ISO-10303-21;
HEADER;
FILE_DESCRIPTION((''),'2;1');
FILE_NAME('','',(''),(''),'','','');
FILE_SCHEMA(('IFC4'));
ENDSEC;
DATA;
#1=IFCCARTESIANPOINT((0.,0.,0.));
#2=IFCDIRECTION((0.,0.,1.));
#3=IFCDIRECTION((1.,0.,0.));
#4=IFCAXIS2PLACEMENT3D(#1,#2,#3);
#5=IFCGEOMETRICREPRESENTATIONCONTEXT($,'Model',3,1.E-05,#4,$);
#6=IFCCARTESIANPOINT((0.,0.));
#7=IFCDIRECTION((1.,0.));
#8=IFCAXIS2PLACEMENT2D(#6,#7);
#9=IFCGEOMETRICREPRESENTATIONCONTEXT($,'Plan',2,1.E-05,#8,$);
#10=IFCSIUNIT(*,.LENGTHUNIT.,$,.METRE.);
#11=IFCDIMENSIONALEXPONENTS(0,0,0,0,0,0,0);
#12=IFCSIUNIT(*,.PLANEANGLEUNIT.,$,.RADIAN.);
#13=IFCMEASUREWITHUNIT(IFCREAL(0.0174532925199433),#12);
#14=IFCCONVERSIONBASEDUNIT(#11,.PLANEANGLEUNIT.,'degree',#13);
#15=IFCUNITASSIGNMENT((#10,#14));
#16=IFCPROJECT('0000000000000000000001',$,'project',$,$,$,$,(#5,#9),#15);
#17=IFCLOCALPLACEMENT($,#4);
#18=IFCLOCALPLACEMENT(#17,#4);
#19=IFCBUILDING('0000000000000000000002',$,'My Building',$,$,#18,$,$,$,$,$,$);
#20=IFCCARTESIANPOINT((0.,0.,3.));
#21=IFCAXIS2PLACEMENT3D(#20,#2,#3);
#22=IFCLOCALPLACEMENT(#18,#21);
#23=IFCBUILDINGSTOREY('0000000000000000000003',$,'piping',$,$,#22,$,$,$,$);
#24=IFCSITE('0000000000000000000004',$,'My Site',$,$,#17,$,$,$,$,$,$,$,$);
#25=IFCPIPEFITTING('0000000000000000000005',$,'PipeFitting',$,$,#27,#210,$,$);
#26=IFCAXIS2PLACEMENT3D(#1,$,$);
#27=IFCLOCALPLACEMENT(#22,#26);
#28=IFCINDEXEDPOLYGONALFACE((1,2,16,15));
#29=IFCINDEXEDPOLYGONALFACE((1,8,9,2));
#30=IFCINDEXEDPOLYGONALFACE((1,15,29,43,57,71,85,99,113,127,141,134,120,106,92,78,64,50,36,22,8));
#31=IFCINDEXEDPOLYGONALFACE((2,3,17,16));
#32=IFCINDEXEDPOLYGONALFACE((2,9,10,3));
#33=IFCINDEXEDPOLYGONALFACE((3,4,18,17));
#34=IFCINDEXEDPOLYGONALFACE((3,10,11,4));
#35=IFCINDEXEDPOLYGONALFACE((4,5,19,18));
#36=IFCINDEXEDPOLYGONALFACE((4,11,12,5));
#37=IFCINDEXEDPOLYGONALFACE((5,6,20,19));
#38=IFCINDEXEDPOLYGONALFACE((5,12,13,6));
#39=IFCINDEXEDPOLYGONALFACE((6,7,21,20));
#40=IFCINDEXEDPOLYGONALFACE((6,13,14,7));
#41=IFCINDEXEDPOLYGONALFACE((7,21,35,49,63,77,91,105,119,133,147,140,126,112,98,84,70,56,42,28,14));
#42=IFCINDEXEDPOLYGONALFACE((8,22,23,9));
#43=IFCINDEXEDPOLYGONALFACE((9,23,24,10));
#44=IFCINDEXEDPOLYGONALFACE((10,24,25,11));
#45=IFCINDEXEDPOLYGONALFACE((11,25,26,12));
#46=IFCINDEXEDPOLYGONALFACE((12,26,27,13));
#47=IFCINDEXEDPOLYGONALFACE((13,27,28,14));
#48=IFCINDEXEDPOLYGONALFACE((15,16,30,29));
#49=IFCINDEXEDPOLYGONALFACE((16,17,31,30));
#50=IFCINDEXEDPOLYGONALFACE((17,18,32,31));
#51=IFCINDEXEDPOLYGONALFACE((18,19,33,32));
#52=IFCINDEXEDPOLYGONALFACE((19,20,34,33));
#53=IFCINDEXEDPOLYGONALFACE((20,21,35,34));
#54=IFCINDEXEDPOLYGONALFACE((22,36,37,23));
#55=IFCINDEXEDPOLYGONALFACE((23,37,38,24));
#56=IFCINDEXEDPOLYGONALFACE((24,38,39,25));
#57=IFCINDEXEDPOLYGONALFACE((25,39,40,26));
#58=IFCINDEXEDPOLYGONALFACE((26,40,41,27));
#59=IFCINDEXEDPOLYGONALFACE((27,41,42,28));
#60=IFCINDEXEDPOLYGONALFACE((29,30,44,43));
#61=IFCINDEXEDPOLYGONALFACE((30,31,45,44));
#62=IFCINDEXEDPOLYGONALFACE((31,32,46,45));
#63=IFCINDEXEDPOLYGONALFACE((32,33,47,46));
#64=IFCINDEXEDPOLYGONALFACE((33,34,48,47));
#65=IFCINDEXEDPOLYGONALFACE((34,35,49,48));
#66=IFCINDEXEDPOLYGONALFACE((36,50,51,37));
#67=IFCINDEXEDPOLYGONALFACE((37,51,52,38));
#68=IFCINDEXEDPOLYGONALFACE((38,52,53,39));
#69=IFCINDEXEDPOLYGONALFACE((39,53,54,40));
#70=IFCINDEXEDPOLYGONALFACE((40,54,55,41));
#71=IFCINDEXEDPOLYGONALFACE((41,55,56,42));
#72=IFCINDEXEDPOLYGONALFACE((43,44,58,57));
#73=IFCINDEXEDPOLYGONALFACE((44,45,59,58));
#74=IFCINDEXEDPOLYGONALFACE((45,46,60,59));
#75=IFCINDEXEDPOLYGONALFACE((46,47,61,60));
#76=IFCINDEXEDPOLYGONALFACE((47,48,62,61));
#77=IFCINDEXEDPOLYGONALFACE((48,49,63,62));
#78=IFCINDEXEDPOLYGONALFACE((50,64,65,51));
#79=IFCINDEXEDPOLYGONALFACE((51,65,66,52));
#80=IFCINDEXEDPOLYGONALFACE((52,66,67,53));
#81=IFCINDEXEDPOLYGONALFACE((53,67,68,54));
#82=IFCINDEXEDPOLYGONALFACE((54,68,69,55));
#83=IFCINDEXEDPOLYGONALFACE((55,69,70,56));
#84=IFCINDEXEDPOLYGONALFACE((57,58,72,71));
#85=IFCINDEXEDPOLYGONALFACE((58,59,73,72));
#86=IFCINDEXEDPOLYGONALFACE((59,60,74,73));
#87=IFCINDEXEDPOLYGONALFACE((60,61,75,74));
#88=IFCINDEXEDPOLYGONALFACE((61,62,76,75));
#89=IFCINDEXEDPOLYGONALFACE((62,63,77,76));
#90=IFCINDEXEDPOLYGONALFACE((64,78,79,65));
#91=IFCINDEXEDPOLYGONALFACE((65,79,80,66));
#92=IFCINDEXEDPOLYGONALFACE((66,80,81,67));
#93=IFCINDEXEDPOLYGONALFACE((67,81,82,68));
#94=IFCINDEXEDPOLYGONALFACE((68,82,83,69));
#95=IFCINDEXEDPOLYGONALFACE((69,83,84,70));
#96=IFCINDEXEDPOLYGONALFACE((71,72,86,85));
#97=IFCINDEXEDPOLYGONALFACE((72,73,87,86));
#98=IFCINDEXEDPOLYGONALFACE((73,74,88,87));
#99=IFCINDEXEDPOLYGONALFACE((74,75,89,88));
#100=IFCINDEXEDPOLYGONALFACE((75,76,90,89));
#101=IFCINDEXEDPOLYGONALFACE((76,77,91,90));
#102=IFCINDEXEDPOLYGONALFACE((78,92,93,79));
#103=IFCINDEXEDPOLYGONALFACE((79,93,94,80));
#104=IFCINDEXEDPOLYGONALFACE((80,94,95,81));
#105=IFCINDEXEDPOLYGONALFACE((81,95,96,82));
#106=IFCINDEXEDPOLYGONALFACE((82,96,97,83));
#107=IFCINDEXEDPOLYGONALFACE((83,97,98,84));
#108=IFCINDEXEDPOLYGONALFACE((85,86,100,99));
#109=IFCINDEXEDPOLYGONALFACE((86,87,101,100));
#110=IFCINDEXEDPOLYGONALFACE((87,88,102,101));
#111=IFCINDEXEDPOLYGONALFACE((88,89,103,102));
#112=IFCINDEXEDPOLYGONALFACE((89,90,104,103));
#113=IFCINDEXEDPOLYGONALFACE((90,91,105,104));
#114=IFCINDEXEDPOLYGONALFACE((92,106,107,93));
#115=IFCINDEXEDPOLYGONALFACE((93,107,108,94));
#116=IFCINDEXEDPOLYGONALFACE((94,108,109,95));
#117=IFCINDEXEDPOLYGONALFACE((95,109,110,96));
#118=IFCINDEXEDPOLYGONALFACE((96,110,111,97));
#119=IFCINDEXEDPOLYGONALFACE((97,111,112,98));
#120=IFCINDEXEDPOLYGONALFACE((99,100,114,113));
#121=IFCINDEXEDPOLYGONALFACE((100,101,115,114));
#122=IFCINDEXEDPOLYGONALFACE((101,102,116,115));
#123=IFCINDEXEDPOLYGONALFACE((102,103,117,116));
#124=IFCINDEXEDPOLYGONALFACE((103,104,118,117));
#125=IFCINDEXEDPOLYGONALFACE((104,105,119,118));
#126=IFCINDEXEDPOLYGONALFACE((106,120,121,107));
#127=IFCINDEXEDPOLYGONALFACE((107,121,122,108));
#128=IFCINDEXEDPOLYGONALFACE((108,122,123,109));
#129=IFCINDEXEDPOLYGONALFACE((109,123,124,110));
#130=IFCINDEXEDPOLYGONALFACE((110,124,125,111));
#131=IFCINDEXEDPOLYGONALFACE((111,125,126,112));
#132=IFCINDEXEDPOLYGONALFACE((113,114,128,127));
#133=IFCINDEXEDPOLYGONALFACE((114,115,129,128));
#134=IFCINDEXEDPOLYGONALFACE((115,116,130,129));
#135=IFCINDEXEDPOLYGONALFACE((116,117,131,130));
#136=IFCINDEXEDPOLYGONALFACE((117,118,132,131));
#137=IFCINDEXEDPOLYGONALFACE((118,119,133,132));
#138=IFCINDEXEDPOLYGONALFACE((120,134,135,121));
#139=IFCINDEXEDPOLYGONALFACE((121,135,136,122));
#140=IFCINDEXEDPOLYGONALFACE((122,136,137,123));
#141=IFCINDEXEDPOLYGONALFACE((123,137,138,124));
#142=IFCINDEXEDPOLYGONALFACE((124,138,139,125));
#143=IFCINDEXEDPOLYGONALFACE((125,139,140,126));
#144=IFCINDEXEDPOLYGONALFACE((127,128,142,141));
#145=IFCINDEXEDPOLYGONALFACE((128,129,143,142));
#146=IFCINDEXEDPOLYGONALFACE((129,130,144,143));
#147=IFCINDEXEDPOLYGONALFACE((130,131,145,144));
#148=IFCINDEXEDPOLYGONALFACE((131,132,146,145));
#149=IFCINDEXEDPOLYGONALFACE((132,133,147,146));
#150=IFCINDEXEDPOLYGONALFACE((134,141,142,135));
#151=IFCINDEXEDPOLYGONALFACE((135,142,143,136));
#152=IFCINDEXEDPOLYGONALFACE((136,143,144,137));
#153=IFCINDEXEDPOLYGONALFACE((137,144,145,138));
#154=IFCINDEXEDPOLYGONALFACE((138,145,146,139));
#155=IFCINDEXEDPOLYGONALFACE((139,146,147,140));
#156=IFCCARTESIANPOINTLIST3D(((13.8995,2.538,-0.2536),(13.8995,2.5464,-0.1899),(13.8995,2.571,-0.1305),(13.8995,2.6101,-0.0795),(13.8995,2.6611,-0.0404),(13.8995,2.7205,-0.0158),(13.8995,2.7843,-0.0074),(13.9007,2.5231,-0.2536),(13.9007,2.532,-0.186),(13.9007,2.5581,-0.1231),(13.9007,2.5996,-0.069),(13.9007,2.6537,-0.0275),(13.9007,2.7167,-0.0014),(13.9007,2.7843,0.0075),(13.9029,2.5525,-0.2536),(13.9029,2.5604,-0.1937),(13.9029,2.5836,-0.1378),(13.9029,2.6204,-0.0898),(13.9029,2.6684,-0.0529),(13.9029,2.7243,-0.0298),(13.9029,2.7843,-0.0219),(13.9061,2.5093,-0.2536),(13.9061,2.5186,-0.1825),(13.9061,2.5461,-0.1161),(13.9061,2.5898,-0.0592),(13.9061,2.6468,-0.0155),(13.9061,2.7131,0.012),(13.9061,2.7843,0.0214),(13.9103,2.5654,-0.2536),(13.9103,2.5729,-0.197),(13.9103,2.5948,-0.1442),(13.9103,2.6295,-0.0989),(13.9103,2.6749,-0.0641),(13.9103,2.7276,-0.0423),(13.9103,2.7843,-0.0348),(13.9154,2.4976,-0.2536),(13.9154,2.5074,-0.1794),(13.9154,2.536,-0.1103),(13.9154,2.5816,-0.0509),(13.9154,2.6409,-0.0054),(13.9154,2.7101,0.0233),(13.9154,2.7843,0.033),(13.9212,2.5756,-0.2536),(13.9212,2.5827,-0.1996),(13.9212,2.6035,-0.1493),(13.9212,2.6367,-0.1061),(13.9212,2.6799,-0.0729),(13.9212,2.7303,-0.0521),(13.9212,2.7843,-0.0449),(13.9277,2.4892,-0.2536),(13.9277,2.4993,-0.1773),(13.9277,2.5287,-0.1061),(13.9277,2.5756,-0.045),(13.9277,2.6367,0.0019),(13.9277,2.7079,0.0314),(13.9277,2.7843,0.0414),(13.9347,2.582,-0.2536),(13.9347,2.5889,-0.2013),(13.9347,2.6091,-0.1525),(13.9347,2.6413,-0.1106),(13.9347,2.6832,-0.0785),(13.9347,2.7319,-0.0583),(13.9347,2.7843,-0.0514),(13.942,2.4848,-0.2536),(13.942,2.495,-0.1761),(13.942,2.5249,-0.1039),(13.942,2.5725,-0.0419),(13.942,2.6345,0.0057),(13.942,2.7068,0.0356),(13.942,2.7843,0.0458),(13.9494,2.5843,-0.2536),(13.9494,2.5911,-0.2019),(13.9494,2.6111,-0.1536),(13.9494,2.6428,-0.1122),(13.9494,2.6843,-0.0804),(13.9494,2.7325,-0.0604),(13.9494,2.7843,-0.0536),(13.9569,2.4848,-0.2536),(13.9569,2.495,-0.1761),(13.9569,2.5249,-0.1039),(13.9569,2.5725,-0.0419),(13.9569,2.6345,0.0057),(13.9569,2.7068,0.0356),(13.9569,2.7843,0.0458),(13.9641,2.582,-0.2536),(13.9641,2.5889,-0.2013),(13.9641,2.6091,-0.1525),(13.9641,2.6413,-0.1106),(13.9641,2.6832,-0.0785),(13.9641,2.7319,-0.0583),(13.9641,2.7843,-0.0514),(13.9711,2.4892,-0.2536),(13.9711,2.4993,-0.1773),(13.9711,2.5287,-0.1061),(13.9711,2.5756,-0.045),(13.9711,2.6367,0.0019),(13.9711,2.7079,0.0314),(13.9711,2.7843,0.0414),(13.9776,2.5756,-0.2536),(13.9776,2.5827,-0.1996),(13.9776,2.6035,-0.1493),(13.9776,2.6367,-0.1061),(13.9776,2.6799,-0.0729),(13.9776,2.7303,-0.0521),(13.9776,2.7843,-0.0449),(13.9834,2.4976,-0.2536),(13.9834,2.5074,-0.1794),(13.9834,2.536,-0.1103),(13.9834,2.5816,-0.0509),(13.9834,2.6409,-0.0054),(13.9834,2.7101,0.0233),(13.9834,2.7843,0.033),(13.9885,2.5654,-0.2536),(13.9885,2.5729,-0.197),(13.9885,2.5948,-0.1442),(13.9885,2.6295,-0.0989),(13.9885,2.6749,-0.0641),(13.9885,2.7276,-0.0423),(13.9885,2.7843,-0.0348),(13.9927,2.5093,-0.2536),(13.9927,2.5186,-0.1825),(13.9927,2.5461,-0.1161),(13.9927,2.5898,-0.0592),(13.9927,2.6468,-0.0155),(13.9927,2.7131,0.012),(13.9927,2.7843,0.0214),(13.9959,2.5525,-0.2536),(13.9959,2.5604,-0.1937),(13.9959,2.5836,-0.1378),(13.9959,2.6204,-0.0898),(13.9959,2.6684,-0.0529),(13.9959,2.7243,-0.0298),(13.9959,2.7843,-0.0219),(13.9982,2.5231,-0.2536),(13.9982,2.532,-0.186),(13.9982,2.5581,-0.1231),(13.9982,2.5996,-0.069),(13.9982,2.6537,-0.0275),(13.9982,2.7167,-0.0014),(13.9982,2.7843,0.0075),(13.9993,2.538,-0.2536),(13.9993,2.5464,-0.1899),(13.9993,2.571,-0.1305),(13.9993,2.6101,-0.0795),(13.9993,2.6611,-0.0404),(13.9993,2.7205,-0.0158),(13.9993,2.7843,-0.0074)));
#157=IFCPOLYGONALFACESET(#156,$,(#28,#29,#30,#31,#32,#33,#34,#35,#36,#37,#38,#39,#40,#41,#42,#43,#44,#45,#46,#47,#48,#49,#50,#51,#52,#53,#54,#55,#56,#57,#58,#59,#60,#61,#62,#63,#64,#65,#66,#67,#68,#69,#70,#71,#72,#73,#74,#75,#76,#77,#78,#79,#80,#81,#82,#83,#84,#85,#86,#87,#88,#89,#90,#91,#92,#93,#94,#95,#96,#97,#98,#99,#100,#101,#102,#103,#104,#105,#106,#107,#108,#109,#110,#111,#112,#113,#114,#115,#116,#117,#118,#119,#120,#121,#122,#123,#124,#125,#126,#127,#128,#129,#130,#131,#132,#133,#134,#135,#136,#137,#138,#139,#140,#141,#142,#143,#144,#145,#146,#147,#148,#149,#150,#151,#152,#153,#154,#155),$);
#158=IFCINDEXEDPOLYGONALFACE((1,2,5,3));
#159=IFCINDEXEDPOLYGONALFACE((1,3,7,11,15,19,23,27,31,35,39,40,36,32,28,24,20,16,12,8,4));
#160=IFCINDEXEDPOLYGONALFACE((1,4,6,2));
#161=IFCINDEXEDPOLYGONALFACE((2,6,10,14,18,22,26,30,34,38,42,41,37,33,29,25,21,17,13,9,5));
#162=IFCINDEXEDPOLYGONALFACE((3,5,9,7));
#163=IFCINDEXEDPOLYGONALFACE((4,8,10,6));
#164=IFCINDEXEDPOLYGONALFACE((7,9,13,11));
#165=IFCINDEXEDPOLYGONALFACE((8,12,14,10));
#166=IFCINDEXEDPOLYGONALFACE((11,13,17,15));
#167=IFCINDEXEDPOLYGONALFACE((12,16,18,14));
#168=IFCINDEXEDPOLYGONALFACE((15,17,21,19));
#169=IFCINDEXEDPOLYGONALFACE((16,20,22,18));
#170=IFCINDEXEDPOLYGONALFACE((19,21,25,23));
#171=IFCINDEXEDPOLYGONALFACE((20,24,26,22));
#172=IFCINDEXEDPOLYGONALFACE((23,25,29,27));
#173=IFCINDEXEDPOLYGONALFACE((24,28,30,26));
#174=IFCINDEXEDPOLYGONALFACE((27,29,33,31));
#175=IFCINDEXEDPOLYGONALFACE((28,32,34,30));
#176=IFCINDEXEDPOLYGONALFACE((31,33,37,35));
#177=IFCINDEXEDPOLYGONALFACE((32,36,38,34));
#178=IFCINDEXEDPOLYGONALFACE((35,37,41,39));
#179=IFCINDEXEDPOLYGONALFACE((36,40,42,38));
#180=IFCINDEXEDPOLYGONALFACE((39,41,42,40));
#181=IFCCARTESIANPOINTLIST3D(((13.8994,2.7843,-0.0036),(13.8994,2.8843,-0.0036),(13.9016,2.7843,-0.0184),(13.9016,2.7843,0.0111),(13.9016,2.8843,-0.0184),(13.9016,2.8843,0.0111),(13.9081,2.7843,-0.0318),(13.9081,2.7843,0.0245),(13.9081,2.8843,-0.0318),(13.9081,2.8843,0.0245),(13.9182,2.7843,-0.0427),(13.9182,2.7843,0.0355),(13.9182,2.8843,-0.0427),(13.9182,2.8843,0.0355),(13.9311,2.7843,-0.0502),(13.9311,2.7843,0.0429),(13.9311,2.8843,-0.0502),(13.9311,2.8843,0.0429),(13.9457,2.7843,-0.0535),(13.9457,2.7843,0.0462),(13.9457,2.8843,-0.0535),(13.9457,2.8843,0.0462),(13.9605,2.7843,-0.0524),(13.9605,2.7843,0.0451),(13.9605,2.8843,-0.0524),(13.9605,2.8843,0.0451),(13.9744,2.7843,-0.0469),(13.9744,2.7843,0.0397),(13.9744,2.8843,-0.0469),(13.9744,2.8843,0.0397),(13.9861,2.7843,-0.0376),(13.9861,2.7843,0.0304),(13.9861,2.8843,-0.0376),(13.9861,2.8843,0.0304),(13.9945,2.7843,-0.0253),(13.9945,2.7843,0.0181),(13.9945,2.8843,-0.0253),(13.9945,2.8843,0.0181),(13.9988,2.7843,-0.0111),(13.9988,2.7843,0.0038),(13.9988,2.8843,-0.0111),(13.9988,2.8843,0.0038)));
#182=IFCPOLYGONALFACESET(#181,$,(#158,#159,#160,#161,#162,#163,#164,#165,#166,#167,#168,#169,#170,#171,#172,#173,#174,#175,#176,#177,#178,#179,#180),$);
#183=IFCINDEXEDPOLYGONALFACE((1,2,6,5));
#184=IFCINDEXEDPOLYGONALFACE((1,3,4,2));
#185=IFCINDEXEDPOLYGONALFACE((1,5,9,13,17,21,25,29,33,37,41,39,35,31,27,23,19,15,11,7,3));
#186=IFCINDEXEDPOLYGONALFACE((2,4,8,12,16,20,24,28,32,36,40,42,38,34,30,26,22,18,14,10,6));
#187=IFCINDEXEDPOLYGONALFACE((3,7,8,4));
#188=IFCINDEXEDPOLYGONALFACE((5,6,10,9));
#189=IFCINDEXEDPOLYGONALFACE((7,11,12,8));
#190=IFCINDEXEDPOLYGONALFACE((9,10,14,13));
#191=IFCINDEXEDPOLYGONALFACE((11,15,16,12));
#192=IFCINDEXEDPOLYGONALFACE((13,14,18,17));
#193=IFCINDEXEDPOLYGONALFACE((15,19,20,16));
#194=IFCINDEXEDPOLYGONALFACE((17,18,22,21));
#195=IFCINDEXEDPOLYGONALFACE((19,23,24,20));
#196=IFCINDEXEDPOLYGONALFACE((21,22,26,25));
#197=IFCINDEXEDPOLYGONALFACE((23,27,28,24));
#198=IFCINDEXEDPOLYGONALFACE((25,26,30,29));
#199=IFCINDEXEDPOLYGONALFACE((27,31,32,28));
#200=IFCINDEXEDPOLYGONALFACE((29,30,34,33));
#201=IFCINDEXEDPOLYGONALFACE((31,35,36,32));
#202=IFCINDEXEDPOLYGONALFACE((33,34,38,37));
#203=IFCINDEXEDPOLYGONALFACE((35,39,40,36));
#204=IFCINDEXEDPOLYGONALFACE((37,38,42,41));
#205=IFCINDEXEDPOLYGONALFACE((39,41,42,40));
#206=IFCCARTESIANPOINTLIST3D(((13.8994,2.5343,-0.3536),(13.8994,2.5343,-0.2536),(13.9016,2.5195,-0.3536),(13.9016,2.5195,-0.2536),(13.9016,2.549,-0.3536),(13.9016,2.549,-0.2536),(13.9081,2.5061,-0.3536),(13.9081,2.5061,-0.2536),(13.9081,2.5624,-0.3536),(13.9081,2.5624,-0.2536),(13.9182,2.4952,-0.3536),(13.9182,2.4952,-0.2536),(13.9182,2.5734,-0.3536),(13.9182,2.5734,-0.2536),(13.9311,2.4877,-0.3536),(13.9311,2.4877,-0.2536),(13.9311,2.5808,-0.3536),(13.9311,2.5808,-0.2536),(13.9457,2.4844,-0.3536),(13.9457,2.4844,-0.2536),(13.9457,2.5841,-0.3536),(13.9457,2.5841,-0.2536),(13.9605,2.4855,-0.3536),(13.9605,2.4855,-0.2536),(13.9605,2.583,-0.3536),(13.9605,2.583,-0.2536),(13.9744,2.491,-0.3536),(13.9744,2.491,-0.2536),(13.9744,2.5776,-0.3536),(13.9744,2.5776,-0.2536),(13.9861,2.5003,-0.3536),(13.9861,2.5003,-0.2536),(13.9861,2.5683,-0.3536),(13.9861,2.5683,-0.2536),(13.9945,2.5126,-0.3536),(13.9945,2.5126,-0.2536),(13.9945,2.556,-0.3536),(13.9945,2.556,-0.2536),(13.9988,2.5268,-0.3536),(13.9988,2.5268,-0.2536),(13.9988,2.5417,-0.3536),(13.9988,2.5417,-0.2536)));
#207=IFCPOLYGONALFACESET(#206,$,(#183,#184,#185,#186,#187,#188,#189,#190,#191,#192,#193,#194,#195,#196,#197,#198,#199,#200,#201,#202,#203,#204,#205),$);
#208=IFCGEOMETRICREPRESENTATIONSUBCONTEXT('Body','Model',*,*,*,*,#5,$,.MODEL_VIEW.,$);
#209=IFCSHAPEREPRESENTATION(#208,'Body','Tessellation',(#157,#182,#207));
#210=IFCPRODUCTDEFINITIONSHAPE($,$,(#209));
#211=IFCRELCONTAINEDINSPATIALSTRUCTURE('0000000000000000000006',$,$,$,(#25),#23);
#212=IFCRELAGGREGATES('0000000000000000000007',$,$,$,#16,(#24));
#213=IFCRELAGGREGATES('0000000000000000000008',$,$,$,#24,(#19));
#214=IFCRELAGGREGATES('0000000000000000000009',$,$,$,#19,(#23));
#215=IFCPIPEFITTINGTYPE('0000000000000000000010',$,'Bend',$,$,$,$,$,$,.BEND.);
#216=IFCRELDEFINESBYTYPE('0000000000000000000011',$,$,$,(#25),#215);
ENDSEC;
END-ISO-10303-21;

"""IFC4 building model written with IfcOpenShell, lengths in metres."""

from ifc_helpers import new_model, entity, si_unit, converted_unit, frame, origin_with_axes, origin_2d_with_axis, place, context, subcontext, project, spatial, circle, extrude, source, transform, mapped, type_object, type_shapes, element, save


model = new_model("IFC4")

# Units and contexts
model_context = context("Model", 3, precision=1e-05, world=origin_with_axes())
plan_context = context("Plan", 2, precision=1e-05, world=origin_2d_with_axis())
body_context = subcontext(model_context, "Body", "Model", "MODEL_VIEW")
ifc_project = project(units=[si_unit("LENGTHUNIT", "METRE"), converted_unit("PLANEANGLEUNIT", "degree", entity("IfcReal", 0.0174532925199433), si_unit("PLANEANGLEUNIT", "RADIAN"), dimensions=[0, 0, 0, 0, 0, 0, 0])], contexts=[model_context, plan_context])

# Site, building, storey
site_placement = place(None, origin_with_axes())
site = spatial("IfcSite", under=ifc_project, at=site_placement, Name="My Site")
building_placement = place(site_placement, origin_with_axes())
building = spatial("IfcBuilding", under=site, at=building_placement, Name="My Building")
storey_placement = place(building_placement, frame((0.0, 0.0, 3.0), z_axis=(0.0, 0.0, 1.0), x_axis=(1.0, 0.0, 0.0)))
storey = spatial("IfcBuildingStorey", under=building, at=storey_placement, Name="piping")

# Pipe fitting
pipe_fitting_type = type_object("IfcPipeFittingType", Name="Bend", PredefinedType="BEND")
shared_shape = source(origin_with_axes(), body_context, "Body", "SolidModel", [
    entity("IfcSweptDiskSolid", entity("IfcIndexedPolyCurve", entity("IfcCartesianPointList3D", [[0.0, 0.0, -0.1], [0.0, -0.0732, -0.2768], [0.0, -0.25, -0.35]]), [entity("IfcArcIndex", [1, 2, 3])]), 0.05),
    extrude(circle(Radius=0.05), origin_with_axes(), (0.0, 0.0, -1.0), 0.1),
    extrude(circle(Radius=0.05), frame((0.0, -0.25, -0.35), z_axis=(0.0, -1.0, 0.0), x_axis=(1.0, 0.0, 0.0)), (0.0, 0.0, 1.0), 0.1),
])
type_shapes(pipe_fitting_type, [shared_shape])
for number, where, z_axis, x_axis, name in (
    (1, (13.9494, 2.8843, -0.0036), (0.0, 1.0, 0.0), (-1.0, 0.0, 0.0), "PipeFitting"),
):
    element("IfcPipeFitting", number, at=place(storey_placement, frame(where, z_axis=z_axis, x_axis=x_axis)), inside=storey, type_object=pipe_fitting_type, Name=name, context=body_context, shape_type="MappedRepresentation", body=[
        mapped(shared_shape, transform((0.0, 0.0, 0.0), x_axis=(1.0, 0.0, 0.0), y_axis=(0.0, 1.0, 0.0), z_axis=(0.0, 0.0, 1.0), scale=1.0)),
    ])

save(model, "model.ifc")
